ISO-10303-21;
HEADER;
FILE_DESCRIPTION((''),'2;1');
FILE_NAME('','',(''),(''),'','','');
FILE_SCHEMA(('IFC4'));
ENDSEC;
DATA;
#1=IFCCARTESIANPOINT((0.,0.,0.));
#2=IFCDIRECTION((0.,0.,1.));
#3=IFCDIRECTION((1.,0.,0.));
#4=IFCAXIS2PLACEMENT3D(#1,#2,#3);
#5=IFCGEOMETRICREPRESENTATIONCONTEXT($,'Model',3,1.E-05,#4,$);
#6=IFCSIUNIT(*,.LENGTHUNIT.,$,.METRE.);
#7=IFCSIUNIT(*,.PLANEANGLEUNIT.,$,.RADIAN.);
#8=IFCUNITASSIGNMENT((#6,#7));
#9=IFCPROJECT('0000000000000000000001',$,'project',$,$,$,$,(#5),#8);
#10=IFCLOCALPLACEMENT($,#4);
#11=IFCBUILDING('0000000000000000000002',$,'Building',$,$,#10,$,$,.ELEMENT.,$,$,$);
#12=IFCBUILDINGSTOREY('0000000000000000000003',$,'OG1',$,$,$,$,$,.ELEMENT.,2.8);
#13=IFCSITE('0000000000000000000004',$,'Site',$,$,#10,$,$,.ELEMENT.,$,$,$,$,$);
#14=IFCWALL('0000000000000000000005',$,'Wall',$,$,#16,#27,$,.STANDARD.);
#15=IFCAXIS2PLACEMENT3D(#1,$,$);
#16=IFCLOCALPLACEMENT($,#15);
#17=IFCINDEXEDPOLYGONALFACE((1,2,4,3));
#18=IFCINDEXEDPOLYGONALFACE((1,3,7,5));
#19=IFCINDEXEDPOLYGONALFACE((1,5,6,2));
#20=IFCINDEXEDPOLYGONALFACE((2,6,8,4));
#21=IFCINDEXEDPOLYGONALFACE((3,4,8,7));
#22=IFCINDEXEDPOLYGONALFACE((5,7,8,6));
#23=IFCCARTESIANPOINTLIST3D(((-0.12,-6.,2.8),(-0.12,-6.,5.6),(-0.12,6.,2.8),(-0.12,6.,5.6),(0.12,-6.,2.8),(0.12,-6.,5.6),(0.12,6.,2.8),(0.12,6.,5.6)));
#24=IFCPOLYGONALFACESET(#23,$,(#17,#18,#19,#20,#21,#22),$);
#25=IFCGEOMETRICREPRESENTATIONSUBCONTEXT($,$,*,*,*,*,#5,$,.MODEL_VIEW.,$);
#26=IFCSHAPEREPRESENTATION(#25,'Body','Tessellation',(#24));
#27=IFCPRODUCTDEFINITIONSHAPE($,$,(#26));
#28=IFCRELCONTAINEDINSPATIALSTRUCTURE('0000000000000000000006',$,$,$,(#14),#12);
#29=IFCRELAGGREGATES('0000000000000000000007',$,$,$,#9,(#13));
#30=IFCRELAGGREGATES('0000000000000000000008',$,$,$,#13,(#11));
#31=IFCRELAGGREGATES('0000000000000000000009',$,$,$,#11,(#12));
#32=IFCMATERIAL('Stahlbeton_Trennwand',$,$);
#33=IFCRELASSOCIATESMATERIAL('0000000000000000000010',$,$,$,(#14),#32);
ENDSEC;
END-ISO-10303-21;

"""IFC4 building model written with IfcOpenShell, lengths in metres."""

from ifc_helpers import new_model, si_unit, frame, frame_2d, origin, origin_with_axes, place, context, subcontext, project, spatial, rectangle, extrude, material, element, save


model = new_model("IFC4")

# Units and contexts
model_context = context("Model", 3, precision=1e-05, world=origin_with_axes())
sub_context = subcontext(model_context, None, None, "MODEL_VIEW")
ifc_project = project(units=[si_unit("LENGTHUNIT", "METRE"), si_unit("PLANEANGLEUNIT", "RADIAN")], contexts=[model_context])

# Site, building, storey
placement_1 = place(None, origin_with_axes())
site = spatial("IfcSite", under=ifc_project, at=placement_1, Name="Site", CompositionType="ELEMENT")
building = spatial("IfcBuilding", under=site, at=placement_1, Name="Building", CompositionType="ELEMENT")
storey = spatial("IfcBuildingStorey", under=building, Name="OG1", CompositionType="ELEMENT", Elevation=2.8)

# Wall
ifc_material = material(Name="Stahlbeton_Trennwand")
placement_2 = place(None, origin_with_axes())
placement_3 = place(placement_2, frame((0.0, 0.0, 2.8)))
wall_placement = place(placement_3, frame((0.0, -6.0, 0.0), x_axis=(0.0, 1.0, 0.0)))
element("IfcWall", 1, at=wall_placement, inside=storey, material=ifc_material, Name="Wall", PredefinedType="STANDARD", context=sub_context, shape_type="SweptSolid", body=[
    extrude(rectangle(XDim=12.0, YDim=0.24, at=frame_2d((6.0, 0.0))), origin(), (0.0, 0.0, 1.0), 2.8),
])

save(model, "model.ifc")
